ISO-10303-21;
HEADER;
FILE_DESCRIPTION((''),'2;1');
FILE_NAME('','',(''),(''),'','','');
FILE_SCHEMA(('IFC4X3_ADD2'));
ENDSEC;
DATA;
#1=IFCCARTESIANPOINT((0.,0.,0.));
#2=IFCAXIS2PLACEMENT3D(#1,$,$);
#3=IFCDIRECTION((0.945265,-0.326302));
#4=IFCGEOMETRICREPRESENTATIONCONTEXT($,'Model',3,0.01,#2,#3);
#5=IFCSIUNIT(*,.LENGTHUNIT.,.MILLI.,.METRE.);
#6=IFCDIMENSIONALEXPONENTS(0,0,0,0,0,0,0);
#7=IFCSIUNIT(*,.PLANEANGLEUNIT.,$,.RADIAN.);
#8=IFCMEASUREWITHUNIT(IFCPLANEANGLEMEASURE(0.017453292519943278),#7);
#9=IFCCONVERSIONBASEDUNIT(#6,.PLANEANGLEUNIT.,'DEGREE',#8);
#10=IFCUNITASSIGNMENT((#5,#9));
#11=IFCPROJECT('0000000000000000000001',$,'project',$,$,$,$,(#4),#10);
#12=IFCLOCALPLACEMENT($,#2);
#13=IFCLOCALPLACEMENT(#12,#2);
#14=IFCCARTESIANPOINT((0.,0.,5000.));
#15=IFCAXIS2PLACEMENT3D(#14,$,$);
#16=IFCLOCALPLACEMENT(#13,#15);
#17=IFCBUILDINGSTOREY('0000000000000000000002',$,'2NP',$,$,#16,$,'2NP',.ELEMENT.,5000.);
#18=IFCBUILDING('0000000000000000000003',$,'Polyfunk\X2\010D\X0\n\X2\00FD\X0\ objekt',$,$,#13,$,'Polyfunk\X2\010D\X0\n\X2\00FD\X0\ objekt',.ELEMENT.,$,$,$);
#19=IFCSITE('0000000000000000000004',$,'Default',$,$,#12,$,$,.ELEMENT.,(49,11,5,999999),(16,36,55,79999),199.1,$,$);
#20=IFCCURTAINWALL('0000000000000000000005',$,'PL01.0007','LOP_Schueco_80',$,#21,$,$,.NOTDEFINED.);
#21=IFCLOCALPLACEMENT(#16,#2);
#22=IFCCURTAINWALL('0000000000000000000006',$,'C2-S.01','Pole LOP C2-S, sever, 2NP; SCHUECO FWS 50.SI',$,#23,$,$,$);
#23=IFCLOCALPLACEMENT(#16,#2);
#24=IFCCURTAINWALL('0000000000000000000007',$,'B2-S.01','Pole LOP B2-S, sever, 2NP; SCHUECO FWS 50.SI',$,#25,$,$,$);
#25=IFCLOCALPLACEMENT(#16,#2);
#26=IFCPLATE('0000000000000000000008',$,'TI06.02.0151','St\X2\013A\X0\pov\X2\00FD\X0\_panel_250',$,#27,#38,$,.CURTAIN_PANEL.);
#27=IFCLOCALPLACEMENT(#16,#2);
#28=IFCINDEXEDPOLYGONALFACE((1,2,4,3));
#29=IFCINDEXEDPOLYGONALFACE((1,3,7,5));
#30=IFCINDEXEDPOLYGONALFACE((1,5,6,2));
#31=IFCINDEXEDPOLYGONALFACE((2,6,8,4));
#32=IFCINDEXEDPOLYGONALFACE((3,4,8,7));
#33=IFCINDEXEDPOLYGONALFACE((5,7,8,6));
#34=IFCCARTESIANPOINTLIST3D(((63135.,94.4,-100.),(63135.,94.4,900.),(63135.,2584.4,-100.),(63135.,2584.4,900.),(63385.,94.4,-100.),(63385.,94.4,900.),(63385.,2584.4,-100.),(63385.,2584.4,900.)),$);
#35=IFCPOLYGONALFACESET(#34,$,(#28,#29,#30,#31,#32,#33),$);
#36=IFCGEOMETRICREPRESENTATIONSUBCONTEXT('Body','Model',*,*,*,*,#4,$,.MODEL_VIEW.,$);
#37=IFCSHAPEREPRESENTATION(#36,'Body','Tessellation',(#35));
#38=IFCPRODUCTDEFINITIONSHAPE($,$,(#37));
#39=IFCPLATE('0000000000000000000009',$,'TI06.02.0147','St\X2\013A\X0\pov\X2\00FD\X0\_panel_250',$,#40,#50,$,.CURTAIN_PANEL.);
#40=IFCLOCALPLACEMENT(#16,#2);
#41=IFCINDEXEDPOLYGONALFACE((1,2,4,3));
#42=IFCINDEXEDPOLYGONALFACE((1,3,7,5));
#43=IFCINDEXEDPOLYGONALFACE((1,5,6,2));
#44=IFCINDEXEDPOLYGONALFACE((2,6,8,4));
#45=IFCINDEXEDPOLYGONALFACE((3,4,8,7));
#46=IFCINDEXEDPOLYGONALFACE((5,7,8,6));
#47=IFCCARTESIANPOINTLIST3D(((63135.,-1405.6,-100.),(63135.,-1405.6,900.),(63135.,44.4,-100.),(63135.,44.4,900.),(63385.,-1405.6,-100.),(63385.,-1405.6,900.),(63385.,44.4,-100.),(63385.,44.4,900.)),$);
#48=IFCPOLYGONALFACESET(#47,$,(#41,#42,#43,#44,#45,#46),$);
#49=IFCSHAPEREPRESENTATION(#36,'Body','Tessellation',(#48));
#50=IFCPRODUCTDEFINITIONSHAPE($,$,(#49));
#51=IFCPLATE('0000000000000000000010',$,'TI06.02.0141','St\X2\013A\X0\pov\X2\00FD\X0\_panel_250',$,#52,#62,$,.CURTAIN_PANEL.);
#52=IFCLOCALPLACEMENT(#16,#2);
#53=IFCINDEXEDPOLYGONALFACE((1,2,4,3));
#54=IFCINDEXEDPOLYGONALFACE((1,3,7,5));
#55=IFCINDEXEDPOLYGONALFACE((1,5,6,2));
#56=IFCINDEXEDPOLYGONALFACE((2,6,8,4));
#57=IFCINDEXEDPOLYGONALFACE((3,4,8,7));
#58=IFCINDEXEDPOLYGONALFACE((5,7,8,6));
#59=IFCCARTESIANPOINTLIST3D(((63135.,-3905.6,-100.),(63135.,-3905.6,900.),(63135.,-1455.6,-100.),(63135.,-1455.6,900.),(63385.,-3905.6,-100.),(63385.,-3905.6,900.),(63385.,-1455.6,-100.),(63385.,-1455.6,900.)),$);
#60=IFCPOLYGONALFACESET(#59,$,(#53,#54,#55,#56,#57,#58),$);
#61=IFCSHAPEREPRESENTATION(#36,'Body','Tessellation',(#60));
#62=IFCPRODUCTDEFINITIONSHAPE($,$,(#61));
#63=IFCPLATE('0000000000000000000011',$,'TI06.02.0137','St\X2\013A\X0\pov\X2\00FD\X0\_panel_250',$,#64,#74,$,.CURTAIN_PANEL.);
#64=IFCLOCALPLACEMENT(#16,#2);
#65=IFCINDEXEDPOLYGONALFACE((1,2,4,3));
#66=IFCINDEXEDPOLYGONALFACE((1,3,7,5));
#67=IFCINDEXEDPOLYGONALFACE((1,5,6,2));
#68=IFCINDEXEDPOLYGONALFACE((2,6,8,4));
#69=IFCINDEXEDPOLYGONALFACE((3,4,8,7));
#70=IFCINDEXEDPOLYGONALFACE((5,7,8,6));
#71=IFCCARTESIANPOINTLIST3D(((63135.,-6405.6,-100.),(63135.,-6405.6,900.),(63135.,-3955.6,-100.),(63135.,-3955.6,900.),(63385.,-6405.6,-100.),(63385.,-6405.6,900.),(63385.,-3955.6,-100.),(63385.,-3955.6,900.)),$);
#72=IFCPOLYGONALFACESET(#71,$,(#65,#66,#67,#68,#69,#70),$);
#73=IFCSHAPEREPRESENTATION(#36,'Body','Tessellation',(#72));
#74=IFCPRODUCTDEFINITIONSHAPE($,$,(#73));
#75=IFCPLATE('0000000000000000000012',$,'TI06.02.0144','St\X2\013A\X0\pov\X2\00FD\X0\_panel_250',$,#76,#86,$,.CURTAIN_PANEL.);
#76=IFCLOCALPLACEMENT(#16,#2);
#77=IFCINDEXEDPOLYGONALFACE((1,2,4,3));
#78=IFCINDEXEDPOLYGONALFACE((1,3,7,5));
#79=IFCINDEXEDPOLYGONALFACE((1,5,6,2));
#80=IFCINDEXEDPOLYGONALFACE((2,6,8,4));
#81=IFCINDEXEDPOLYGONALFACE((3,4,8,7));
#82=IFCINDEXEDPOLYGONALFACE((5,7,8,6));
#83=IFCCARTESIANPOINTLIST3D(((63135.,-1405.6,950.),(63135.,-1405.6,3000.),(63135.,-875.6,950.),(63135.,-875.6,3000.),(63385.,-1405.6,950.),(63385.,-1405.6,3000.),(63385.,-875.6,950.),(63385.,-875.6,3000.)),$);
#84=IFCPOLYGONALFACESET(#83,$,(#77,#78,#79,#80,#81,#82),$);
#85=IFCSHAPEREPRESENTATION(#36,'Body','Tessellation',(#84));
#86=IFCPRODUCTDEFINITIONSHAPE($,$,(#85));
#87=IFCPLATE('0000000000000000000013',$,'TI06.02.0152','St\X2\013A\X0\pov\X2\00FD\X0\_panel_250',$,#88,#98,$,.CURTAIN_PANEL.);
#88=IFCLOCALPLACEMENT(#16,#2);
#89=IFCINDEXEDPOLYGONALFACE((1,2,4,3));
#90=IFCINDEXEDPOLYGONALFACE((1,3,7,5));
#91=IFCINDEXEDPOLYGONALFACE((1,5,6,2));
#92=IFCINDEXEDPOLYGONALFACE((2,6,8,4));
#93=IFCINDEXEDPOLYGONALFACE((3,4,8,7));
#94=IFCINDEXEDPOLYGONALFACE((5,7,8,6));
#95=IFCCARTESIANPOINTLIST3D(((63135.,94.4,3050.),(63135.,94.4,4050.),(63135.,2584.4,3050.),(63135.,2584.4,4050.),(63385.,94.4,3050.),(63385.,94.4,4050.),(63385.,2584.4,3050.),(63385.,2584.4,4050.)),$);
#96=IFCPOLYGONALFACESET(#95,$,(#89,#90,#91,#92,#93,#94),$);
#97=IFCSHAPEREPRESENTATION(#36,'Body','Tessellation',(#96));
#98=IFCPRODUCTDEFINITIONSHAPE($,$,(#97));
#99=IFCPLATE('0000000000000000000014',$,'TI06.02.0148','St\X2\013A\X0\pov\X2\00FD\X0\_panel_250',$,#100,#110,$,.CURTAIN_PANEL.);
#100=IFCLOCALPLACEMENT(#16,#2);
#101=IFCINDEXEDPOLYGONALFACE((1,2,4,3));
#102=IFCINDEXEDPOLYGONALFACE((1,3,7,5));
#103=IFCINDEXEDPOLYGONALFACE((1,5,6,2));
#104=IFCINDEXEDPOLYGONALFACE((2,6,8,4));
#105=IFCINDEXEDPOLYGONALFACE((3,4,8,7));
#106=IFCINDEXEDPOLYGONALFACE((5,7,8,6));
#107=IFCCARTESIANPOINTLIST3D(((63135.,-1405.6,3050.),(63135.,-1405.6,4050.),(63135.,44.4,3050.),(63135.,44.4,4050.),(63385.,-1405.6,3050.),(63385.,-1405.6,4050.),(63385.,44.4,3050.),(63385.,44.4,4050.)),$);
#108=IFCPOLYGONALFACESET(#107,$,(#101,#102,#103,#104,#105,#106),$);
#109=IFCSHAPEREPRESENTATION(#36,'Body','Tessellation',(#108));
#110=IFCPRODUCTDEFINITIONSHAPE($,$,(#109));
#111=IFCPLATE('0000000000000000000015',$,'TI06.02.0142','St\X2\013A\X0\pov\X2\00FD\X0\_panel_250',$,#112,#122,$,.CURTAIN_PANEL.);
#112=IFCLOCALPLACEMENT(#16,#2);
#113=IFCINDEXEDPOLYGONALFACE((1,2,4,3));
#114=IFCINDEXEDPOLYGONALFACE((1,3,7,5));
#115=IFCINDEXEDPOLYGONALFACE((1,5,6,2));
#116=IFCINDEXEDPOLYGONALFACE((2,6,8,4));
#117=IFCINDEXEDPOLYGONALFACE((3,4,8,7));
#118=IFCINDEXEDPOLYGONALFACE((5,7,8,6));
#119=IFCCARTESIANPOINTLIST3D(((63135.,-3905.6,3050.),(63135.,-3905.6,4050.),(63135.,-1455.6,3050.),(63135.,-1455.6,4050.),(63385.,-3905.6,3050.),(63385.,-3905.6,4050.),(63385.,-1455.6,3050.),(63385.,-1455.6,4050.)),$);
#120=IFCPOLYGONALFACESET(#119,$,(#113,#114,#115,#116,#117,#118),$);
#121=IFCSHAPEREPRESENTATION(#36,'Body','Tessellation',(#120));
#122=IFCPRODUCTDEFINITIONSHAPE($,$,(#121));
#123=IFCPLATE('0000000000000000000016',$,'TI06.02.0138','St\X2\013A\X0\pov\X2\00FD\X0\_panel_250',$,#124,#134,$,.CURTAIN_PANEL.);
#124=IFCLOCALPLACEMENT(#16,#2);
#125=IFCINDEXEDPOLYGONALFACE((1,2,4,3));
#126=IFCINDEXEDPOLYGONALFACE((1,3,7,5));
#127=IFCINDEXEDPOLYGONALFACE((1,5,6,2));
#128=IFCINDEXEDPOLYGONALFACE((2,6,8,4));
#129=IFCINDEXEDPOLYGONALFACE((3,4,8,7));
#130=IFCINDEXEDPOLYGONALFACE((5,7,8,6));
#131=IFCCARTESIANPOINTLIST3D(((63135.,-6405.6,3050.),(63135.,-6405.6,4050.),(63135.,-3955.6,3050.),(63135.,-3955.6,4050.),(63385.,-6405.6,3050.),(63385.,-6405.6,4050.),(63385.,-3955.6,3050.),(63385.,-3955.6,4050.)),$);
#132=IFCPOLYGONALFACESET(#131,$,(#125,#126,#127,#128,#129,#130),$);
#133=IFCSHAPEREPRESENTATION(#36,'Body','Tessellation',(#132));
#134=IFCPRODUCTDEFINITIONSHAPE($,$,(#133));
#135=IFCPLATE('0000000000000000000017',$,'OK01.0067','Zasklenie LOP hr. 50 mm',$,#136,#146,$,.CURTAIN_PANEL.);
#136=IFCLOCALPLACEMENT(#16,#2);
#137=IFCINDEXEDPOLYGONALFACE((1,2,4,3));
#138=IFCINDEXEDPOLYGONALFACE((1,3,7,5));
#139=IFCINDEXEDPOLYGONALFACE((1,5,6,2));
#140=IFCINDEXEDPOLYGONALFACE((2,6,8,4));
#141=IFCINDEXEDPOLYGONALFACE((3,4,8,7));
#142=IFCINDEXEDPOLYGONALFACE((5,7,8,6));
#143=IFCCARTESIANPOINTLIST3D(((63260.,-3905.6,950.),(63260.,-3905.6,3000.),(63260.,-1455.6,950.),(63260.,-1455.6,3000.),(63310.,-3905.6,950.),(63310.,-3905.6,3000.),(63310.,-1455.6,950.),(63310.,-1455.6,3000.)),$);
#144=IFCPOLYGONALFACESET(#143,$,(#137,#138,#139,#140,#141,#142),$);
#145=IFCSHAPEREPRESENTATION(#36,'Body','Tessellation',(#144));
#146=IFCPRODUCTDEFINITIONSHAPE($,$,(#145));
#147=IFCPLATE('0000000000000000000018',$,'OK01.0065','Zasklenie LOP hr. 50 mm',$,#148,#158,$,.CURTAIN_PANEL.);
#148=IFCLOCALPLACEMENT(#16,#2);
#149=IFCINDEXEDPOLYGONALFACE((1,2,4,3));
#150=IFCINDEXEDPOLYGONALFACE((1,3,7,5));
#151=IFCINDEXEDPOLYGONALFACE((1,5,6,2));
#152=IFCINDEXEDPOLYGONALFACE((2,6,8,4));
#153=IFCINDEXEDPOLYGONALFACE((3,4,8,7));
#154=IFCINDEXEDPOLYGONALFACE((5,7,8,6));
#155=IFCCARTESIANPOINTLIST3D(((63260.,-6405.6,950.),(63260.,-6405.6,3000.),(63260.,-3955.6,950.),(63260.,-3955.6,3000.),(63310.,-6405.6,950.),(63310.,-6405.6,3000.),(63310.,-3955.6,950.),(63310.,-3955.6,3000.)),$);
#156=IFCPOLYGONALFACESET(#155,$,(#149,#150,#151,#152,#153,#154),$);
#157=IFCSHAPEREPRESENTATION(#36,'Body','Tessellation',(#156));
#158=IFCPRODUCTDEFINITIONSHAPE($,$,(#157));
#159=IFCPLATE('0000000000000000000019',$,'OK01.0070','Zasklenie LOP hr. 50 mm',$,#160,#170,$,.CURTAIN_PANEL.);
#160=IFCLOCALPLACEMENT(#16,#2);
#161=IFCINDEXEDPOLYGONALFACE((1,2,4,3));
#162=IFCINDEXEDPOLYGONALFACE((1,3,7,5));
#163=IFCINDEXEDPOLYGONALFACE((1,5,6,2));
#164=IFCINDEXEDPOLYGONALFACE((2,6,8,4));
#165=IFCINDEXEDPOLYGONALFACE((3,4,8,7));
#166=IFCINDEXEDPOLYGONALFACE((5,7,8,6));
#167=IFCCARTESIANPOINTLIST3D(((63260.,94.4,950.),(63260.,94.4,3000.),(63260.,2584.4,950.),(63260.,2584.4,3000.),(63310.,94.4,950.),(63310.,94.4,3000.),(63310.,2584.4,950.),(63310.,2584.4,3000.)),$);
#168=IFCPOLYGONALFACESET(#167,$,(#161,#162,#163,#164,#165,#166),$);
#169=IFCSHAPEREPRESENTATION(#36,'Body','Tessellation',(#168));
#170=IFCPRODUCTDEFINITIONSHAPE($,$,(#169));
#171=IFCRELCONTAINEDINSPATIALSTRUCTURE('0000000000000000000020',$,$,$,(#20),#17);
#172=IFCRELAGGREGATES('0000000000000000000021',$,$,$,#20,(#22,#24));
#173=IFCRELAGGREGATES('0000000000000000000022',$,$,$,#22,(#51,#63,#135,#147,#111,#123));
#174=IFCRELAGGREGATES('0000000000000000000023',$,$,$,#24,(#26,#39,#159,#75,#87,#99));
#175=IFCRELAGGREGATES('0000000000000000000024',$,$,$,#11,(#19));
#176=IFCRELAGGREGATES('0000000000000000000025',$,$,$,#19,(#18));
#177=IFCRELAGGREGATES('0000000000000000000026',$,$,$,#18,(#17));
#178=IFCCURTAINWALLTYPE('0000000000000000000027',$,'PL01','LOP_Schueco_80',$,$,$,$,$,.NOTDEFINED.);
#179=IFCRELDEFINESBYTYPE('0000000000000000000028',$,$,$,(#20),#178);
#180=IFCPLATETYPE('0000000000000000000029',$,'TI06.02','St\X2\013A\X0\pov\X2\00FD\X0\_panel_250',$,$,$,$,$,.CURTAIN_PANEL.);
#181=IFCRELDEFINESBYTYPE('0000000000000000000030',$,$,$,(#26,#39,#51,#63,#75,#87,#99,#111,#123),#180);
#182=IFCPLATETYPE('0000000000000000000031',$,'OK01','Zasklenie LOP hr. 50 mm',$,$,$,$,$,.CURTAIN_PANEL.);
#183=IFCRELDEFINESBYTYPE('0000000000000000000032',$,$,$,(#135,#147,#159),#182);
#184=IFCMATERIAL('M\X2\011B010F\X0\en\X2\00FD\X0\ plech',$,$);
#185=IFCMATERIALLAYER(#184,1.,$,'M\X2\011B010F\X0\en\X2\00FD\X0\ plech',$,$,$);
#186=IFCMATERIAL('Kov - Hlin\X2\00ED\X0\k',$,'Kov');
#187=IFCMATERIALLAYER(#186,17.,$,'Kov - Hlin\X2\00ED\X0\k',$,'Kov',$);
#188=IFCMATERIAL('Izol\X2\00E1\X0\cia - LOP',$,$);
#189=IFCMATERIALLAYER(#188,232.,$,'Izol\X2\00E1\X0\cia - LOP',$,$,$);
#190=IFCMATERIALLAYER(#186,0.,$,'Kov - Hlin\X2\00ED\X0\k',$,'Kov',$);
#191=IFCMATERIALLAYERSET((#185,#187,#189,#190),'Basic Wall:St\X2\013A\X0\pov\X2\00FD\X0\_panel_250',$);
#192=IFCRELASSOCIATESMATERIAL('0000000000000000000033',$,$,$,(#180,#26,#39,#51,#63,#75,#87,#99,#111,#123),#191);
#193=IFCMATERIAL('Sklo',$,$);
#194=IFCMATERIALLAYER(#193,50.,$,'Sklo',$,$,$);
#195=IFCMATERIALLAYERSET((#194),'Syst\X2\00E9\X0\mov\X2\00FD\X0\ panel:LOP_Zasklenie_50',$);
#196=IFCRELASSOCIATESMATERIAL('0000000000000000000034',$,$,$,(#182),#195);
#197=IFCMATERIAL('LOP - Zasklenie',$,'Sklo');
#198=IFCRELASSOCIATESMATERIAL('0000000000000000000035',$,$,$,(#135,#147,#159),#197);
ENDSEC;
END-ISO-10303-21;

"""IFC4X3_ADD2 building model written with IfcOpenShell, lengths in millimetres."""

from ifc_helpers import new_model, entity, si_unit, converted_unit, direction, frame, frame_2d, origin, origin_2d_with_axis, place, context, subcontext, project, spatial, rectangle, extrude, source, transform, mapped, material, layer, layer_set, layer_usage, type_object, type_shapes, element, aggregate, save


model = new_model("IFC4X3_ADD2")

# Units and contexts
model_context = context("Model", 3, precision=0.01, world=origin(), true_north=direction((0.945265, -0.326302)))
body_context = subcontext(model_context, "Body", "Model", "MODEL_VIEW")
ifc_project = project(units=[si_unit("LENGTHUNIT", "METRE", prefix="MILLI"), converted_unit("PLANEANGLEUNIT", "DEGREE", entity("IfcPlaneAngleMeasure", 0.017453292519943278), si_unit("PLANEANGLEUNIT", "RADIAN"), dimensions=[0, 0, 0, 0, 0, 0, 0])], contexts=[model_context])

# Site, building, storey
site_placement = place(None, origin())
site = spatial("IfcSite", under=ifc_project, at=site_placement, Name="Default", CompositionType="ELEMENT", RefLatitude=(49, 11, 5, 999999), RefLongitude=(16, 36, 55, 79999), RefElevation=199.1)
building_placement = place(site_placement, origin())
building = spatial("IfcBuilding", under=site, at=building_placement, Name="Polyfunkčný objekt", LongName="Polyfunkčný objekt", CompositionType="ELEMENT")
storey_placement = place(building_placement, frame((0.0, 0.0, 5000.0)))
storey = spatial("IfcBuildingStorey", under=building, at=storey_placement, Name="2NP", LongName="2NP", CompositionType="ELEMENT", Elevation=5000.0)

# Curtain walls, plates
curtain_wall_type = type_object("IfcCurtainWallType", Name="PL01", Description="LOP_Schueco_80", PredefinedType="NOTDEFINED")
curtain_wall_1_placement = place(storey_placement, frame((0.0, 0.0, -5000.0)))
curtain_wall_1 = element("IfcCurtainWall", 1, at=curtain_wall_1_placement, inside=storey, type_object=curtain_wall_type, Name="PL01.0007", Description="LOP_Schueco_80", PredefinedType="NOTDEFINED")
curtain_wall_2 = element("IfcCurtainWall", 2, Name="C2-S.01", Description="Pole LOP C2-S, sever, 2NP; SCHUECO FWS 50.SI")
curtain_wall_3 = element("IfcCurtainWall", 3, Name="B2-S.01", Description="Pole LOP B2-S, sever, 2NP; SCHUECO FWS 50.SI")
aggregate(curtain_wall_1, [curtain_wall_2, curtain_wall_3])
ifc_material_1 = material(Name="Měďený plech")
ifc_layer_1 = layer(ifc_material_1, 1.0, Name="Měďený plech")
ifc_material_2 = material(Name="Kov - Hliník", Category="Kov")
ifc_layer_2 = layer(ifc_material_2, 17.0, Name="Kov - Hliník", Category="Kov")
ifc_material_3 = material(Name="Izolácia - LOP")
ifc_layer_3 = layer(ifc_material_3, 232.0, Name="Izolácia - LOP")
ifc_layer_4 = layer(ifc_material_2, 0.0, Name="Kov - Hliník", Category="Kov")
ifc_layer_set_1 = layer_set([ifc_layer_1, ifc_layer_2, ifc_layer_3, ifc_layer_4], Name="Basic Wall:Stĺpový_panel_250")
ifc_layer_usage_1 = layer_usage(ifc_layer_set_1, "AXIS2", "NEGATIVE", 125.0)
plate_type_1 = type_object("IfcPlateType", Name="TI06.02", Description="Stĺpový_panel_250", PredefinedType="CURTAIN_PANEL", material=ifc_layer_set_1)
plate_1_placement = place(storey_placement, frame((63260.0, 2584.4, -100.0), z_axis=(0.0, 0.0, 1.0), x_axis=(0.0, -1.0, 0.0)))
plate_1 = element("IfcPlate", 4, at=plate_1_placement, type_object=plate_type_1, material=ifc_layer_usage_1, Name="TI06.02.0151", Description="Stĺpový_panel_250", PredefinedType="CURTAIN_PANEL", context=body_context, shape_type="SweptSolid", body=[
    extrude(rectangle(XDim=250.0, YDim=2490.0, at=frame_2d((0.0, 0.0), x_axis=(1.0, 0.0))), frame((1245.0, 0.0, 0.0), z_axis=(0.0, 0.0, 1.0), x_axis=(0.0, 1.0, 0.0)), (0.0, 0.0, 1.0), 1000.0),
])
ifc_layer_usage_2 = layer_usage(ifc_layer_set_1, "AXIS2", "NEGATIVE", 125.0)
plate_2_placement = place(storey_placement, frame((63260.0, 44.4, -100.0), z_axis=(0.0, 0.0, 1.0), x_axis=(0.0, -1.0, 0.0)))
plate_2 = element("IfcPlate", 5, at=plate_2_placement, type_object=plate_type_1, material=ifc_layer_usage_2, Name="TI06.02.0147", Description="Stĺpový_panel_250", PredefinedType="CURTAIN_PANEL", context=body_context, shape_type="SweptSolid", body=[
    extrude(rectangle(XDim=250.0, YDim=1450.0, at=frame_2d((0.0, 0.0), x_axis=(1.0, 0.0))), frame((725.0, 0.0, 0.0), z_axis=(0.0, 0.0, 1.0), x_axis=(0.0, 1.0, 0.0)), (0.0, 0.0, 1.0), 1000.0),
])
ifc_layer_usage_3 = layer_usage(ifc_layer_set_1, "AXIS2", "NEGATIVE", 125.0)
plate_3_placement = place(storey_placement, frame((63260.0, -1455.6, -100.0), z_axis=(0.0, 0.0, 1.0), x_axis=(0.0, -1.0, 0.0)))
plate_3 = element("IfcPlate", 6, at=plate_3_placement, type_object=plate_type_1, material=ifc_layer_usage_3, Name="TI06.02.0141", Description="Stĺpový_panel_250", PredefinedType="CURTAIN_PANEL", context=body_context, shape_type="SweptSolid", body=[
    extrude(rectangle(XDim=250.0, YDim=2450.0, at=frame_2d((0.0, 0.0), x_axis=(1.0, 0.0))), frame((1225.0, 0.0, 0.0), z_axis=(0.0, 0.0, 1.0), x_axis=(0.0, 1.0, 0.0)), (0.0, 0.0, 1.0), 1000.0),
])
ifc_layer_usage_4 = layer_usage(ifc_layer_set_1, "AXIS2", "NEGATIVE", 125.0)
plate_4_placement = place(storey_placement, frame((63260.0, -3955.6, -100.0), z_axis=(0.0, 0.0, 1.0), x_axis=(0.0, -1.0, 0.0)))
plate_4 = element("IfcPlate", 7, at=plate_4_placement, type_object=plate_type_1, material=ifc_layer_usage_4, Name="TI06.02.0137", Description="Stĺpový_panel_250", PredefinedType="CURTAIN_PANEL", context=body_context, shape_type="SweptSolid", body=[
    extrude(rectangle(XDim=250.0, YDim=2450.0, at=frame_2d((0.0, 0.0), x_axis=(1.0, 0.0))), frame((1225.0, 0.0, 0.0), z_axis=(0.0, 0.0, 1.0), x_axis=(0.0, 1.0, 0.0)), (0.0, 0.0, 1.0), 1000.0),
])
ifc_layer_usage_5 = layer_usage(ifc_layer_set_1, "AXIS2", "NEGATIVE", 125.0)
plate_5_placement = place(storey_placement, frame((63260.0, -875.6, 950.0), z_axis=(0.0, 0.0, 1.0), x_axis=(0.0, -1.0, 0.0)))
plate_5 = element("IfcPlate", 8, at=plate_5_placement, type_object=plate_type_1, material=ifc_layer_usage_5, Name="TI06.02.0144", Description="Stĺpový_panel_250", PredefinedType="CURTAIN_PANEL", context=body_context, shape_type="SweptSolid", body=[
    extrude(rectangle(XDim=250.0, YDim=530.0, at=frame_2d((0.0, 0.0), x_axis=(1.0, 0.0))), frame((265.0, 0.0, 0.0), z_axis=(0.0, 0.0, 1.0), x_axis=(0.0, 1.0, 0.0)), (0.0, 0.0, 1.0), 2050.0),
])
ifc_layer_usage_6 = layer_usage(ifc_layer_set_1, "AXIS2", "NEGATIVE", 125.0)
plate_6_placement = place(storey_placement, frame((63260.0, 2584.4, 3050.0), z_axis=(0.0, 0.0, 1.0), x_axis=(0.0, -1.0, 0.0)))
plate_6 = element("IfcPlate", 9, at=plate_6_placement, type_object=plate_type_1, material=ifc_layer_usage_6, Name="TI06.02.0152", Description="Stĺpový_panel_250", PredefinedType="CURTAIN_PANEL", context=body_context, shape_type="SweptSolid", body=[
    extrude(rectangle(XDim=250.0, YDim=2490.0, at=frame_2d((0.0, 0.0), x_axis=(1.0, 0.0))), frame((1245.0, 0.0, 0.0), z_axis=(0.0, 0.0, 1.0), x_axis=(0.0, 1.0, 0.0)), (0.0, 0.0, 1.0), 1000.0),
])
ifc_layer_usage_7 = layer_usage(ifc_layer_set_1, "AXIS2", "NEGATIVE", 125.0)
plate_7_placement = place(storey_placement, frame((63260.0, 44.4, 3050.0), z_axis=(0.0, 0.0, 1.0), x_axis=(0.0, -1.0, 0.0)))
plate_7 = element("IfcPlate", 10, at=plate_7_placement, type_object=plate_type_1, material=ifc_layer_usage_7, Name="TI06.02.0148", Description="Stĺpový_panel_250", PredefinedType="CURTAIN_PANEL", context=body_context, shape_type="SweptSolid", body=[
    extrude(rectangle(XDim=250.0, YDim=1450.0, at=frame_2d((0.0, 0.0), x_axis=(1.0, 0.0))), frame((725.0, 0.0, 0.0), z_axis=(0.0, 0.0, 1.0), x_axis=(0.0, 1.0, 0.0)), (0.0, 0.0, 1.0), 1000.0),
])
ifc_layer_usage_8 = layer_usage(ifc_layer_set_1, "AXIS2", "NEGATIVE", 125.0)
plate_8_placement = place(storey_placement, frame((63260.0, -1455.6, 3050.0), z_axis=(0.0, 0.0, 1.0), x_axis=(0.0, -1.0, 0.0)))
plate_8 = element("IfcPlate", 11, at=plate_8_placement, type_object=plate_type_1, material=ifc_layer_usage_8, Name="TI06.02.0142", Description="Stĺpový_panel_250", PredefinedType="CURTAIN_PANEL", context=body_context, shape_type="SweptSolid", body=[
    extrude(rectangle(XDim=250.0, YDim=2450.0, at=frame_2d((0.0, 0.0), x_axis=(1.0, 0.0))), frame((1225.0, 0.0, 0.0), z_axis=(0.0, 0.0, 1.0), x_axis=(0.0, 1.0, 0.0)), (0.0, 0.0, 1.0), 1000.0),
])
ifc_layer_usage_9 = layer_usage(ifc_layer_set_1, "AXIS2", "NEGATIVE", 125.0)
plate_9_placement = place(storey_placement, frame((63260.0, -3955.6, 3050.0), z_axis=(0.0, 0.0, 1.0), x_axis=(0.0, -1.0, 0.0)))
plate_9 = element("IfcPlate", 12, at=plate_9_placement, type_object=plate_type_1, material=ifc_layer_usage_9, Name="TI06.02.0138", Description="Stĺpový_panel_250", PredefinedType="CURTAIN_PANEL", context=body_context, shape_type="SweptSolid", body=[
    extrude(rectangle(XDim=250.0, YDim=2450.0, at=frame_2d((0.0, 0.0), x_axis=(1.0, 0.0))), frame((1225.0, 0.0, 0.0), z_axis=(0.0, 0.0, 1.0), x_axis=(0.0, 1.0, 0.0)), (0.0, 0.0, 1.0), 1000.0),
])
ifc_material_4 = material(Name="LOP - Zasklenie", Category="Sklo")
ifc_material_5 = material(Name="Sklo")
ifc_layer_5 = layer(ifc_material_5, 50.0, Name="Sklo")
ifc_layer_set_2 = layer_set([ifc_layer_5], Name="Systémový panel:LOP_Zasklenie_50")
plate_type_2 = type_object("IfcPlateType", Name="OK01", Description="Zasklenie LOP hr. 50 mm", PredefinedType="CURTAIN_PANEL", material=ifc_layer_set_2)
shared_shape_1 = source(origin(), body_context, "Body", "SweptSolid", [
    extrude(rectangle(XDim=50.0, YDim=2450.0, at=origin_2d_with_axis()), frame((0.0, 25.0, 0.0), z_axis=(0.0, 0.0, 1.0), x_axis=(0.0, 1.0, 0.0)), (0.0, 0.0, 1.0), 2050.0),
])
plate_10_placement = place(curtain_wall_1_placement, frame((63260.0, -2680.6, 5950.0), z_axis=(0.0, 0.0, 1.0), x_axis=(0.0, -1.0, 0.0)))
plate_10 = element("IfcPlate", 13, at=plate_10_placement, type_object=plate_type_2, material=ifc_material_4, Name="OK01.0067", Description="Zasklenie LOP hr. 50 mm", PredefinedType="CURTAIN_PANEL", context=body_context, shape_type="MappedRepresentation", body=[
    mapped(shared_shape_1, transform((0.0, 0.0, 0.0), scale=1.0)),
])
plate_11_placement = place(curtain_wall_1_placement, frame((63260.0, -5180.6, 5950.0), z_axis=(0.0, 0.0, 1.0), x_axis=(0.0, -1.0, 0.0)))
plate_11 = element("IfcPlate", 14, at=plate_11_placement, type_object=plate_type_2, material=ifc_material_4, Name="OK01.0065", Description="Zasklenie LOP hr. 50 mm", PredefinedType="CURTAIN_PANEL", context=body_context, shape_type="MappedRepresentation", body=[
    mapped(shared_shape_1, transform((0.0, 0.0, 0.0), scale=1.0)),
])
aggregate(curtain_wall_2, [plate_3, plate_4, plate_10, plate_11, plate_8, plate_9])
shared_shape_2 = source(origin(), body_context, "Body", "SweptSolid", [
    extrude(rectangle(XDim=50.0, YDim=2490.0, at=origin_2d_with_axis()), frame((0.0, 25.0, 0.0), z_axis=(0.0, 0.0, 1.0), x_axis=(0.0, 1.0, 0.0)), (0.0, 0.0, 1.0), 2050.0),
])
type_shapes(plate_type_2, [shared_shape_1, shared_shape_2])
plate_12_placement = place(curtain_wall_1_placement, frame((63260.0, 1339.4, 5950.0), z_axis=(0.0, 0.0, 1.0), x_axis=(0.0, -1.0, 0.0)))
plate_12 = element("IfcPlate", 15, at=plate_12_placement, type_object=plate_type_2, material=ifc_material_4, Name="OK01.0070", Description="Zasklenie LOP hr. 50 mm", PredefinedType="CURTAIN_PANEL", context=body_context, shape_type="MappedRepresentation", body=[
    mapped(shared_shape_2, transform((0.0, 0.0, 0.0), scale=1.0)),
])
aggregate(curtain_wall_3, [plate_1, plate_2, plate_12, plate_5, plate_6, plate_7])

save(model, "model.ifc")
